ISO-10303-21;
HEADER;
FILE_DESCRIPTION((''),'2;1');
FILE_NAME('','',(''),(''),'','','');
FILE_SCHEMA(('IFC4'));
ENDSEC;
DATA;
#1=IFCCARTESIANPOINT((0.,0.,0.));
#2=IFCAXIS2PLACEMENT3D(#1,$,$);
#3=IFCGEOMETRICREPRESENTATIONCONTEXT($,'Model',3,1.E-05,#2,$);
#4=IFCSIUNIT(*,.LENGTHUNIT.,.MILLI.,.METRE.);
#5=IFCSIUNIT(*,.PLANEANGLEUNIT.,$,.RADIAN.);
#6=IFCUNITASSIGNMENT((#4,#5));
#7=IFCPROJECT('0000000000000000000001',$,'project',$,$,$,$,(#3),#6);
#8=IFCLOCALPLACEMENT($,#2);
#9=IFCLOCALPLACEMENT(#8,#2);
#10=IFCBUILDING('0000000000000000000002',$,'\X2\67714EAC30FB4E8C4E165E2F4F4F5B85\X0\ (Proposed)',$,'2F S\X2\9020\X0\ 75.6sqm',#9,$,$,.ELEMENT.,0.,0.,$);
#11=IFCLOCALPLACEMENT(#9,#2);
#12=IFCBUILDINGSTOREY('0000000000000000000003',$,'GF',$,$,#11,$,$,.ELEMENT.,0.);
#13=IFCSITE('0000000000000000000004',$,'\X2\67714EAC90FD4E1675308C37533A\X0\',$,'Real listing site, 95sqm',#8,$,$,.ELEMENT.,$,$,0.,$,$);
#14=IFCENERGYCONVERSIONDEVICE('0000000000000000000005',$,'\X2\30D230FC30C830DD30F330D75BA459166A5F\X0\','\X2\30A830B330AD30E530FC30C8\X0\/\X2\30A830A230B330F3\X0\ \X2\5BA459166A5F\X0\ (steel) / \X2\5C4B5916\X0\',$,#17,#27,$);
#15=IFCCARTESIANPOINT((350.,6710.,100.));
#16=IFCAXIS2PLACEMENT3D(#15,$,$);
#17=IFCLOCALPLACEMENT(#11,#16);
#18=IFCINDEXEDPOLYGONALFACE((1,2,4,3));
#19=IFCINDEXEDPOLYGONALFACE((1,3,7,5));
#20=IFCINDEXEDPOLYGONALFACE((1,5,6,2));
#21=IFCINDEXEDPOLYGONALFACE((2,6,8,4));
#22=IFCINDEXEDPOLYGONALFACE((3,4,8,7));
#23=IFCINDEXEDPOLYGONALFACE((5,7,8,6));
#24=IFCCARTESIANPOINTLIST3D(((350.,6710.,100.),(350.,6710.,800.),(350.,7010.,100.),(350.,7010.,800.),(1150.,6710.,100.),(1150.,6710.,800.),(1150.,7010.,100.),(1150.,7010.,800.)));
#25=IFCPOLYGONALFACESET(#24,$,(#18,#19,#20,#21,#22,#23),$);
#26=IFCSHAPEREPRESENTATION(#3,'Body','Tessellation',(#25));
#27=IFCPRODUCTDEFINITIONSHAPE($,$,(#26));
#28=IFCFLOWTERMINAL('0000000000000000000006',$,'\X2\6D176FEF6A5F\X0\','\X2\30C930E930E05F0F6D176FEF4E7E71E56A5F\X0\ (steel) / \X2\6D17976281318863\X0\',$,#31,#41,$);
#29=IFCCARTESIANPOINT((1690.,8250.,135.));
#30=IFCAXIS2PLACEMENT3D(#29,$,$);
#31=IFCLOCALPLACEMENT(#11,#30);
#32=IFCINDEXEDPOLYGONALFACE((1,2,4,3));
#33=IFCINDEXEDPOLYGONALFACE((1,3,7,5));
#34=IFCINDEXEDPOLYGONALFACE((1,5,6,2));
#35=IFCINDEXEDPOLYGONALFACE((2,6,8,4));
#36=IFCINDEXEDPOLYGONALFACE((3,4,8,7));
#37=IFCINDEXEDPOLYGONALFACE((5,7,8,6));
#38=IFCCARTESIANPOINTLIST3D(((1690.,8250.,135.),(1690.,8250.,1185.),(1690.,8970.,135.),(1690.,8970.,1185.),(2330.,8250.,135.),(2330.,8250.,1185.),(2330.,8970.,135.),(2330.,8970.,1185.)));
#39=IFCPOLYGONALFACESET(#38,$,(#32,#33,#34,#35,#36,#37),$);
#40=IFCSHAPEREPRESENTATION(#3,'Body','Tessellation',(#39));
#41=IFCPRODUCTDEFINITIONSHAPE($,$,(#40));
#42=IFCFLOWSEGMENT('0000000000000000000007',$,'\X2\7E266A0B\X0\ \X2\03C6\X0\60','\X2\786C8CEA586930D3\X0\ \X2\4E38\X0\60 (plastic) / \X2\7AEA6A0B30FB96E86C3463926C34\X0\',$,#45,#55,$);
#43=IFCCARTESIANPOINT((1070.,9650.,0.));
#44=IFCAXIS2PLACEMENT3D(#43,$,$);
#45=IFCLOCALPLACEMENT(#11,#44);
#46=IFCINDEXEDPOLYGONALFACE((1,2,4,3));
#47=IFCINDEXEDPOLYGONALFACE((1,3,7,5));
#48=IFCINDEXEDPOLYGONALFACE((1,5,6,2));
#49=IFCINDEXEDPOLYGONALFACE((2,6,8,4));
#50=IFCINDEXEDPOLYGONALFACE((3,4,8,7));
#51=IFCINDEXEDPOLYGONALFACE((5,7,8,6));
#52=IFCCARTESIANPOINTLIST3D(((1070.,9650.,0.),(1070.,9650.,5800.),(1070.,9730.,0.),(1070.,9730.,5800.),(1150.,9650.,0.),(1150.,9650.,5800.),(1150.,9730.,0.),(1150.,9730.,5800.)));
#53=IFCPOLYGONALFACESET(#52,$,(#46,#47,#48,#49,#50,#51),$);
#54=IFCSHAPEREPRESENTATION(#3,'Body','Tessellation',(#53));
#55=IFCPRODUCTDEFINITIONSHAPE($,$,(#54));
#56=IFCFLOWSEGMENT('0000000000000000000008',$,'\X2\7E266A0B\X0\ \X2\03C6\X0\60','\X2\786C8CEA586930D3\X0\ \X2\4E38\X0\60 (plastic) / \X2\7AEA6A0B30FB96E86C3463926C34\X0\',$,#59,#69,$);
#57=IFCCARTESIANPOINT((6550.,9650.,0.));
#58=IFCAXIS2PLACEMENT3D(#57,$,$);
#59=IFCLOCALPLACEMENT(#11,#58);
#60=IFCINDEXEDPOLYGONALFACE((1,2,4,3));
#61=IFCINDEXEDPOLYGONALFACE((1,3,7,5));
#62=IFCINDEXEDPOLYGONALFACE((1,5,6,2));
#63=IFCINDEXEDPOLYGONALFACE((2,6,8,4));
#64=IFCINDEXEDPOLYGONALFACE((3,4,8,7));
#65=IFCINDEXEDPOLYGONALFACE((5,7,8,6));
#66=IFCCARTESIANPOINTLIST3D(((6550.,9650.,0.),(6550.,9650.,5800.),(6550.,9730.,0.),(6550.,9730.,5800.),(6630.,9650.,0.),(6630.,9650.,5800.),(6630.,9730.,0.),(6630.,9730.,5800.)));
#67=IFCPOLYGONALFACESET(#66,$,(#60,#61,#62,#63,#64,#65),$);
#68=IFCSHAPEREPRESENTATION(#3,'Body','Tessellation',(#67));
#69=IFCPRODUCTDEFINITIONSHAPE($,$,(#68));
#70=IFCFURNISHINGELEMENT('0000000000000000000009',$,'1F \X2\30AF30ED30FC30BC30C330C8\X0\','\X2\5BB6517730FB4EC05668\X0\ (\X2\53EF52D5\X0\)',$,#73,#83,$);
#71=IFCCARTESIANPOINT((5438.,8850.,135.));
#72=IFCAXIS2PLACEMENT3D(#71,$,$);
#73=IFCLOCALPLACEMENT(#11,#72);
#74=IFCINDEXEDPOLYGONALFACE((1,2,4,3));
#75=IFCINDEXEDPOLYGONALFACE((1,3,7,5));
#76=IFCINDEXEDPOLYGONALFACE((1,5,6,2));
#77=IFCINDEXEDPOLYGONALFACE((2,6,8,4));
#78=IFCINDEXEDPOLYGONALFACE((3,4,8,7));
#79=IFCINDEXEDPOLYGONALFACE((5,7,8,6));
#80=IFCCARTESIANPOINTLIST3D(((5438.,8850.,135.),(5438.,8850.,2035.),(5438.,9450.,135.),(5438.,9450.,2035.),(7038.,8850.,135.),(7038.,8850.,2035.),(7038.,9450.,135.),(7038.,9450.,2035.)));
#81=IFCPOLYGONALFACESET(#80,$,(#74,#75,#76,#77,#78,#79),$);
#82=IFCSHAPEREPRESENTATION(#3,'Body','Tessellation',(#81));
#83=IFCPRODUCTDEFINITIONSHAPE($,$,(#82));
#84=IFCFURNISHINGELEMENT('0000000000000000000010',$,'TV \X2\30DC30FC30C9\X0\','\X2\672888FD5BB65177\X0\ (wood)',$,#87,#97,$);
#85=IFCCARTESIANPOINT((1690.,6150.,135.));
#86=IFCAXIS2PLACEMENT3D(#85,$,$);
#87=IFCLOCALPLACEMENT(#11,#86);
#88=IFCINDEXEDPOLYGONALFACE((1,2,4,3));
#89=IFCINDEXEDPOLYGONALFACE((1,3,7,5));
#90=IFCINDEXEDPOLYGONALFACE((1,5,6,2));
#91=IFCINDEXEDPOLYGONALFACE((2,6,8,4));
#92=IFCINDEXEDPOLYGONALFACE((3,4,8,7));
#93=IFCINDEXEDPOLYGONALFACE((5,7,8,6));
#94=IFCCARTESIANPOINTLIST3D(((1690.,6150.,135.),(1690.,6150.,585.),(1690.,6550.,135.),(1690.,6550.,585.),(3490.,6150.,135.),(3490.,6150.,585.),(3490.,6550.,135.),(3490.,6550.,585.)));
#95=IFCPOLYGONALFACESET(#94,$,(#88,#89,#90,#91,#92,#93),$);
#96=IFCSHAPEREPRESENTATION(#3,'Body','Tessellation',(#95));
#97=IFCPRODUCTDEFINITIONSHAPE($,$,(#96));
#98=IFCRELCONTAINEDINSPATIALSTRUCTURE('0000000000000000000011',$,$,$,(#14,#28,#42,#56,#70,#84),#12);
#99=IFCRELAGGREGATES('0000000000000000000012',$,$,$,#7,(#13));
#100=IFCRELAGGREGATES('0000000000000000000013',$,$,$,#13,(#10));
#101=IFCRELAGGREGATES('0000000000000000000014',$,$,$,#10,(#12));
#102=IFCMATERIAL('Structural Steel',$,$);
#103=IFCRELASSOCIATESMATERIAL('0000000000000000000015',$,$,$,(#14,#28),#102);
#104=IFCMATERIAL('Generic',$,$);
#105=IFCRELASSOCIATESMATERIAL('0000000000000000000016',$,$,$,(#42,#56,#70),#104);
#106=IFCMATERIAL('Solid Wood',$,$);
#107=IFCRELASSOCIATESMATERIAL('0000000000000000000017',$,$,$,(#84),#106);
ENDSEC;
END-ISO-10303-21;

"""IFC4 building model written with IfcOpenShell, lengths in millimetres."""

from ifc_helpers import new_model, si_unit, frame, frame_2d, origin, place, context, project, spatial, rectangle, extrude, material, element, save


model = new_model("IFC4")

# Units and contexts
model_context = context("Model", 3, precision=1e-05, world=origin())
ifc_project = project(units=[si_unit("LENGTHUNIT", "METRE", prefix="MILLI"), si_unit("PLANEANGLEUNIT", "RADIAN")], contexts=[model_context])

# Site, building, storey
site_placement = place(None, origin())
site = spatial("IfcSite", under=ifc_project, at=site_placement, Name="東京都世田谷区", ObjectType="Real listing site, 95sqm", CompositionType="ELEMENT", RefElevation=0.0)
building_placement = place(site_placement, origin())
building = spatial("IfcBuilding", under=site, at=building_placement, Name="東京・二世帯住宅 (Proposed)", ObjectType="2F S造 75.6sqm", CompositionType="ELEMENT", ElevationOfRefHeight=0.0, ElevationOfTerrain=0.0)
storey_placement = place(building_placement, origin())
storey = spatial("IfcBuildingStorey", under=building, at=storey_placement, Name="GF", CompositionType="ELEMENT", Elevation=0.0)

# Shared definitions
ifc_material_1 = material(Name="Solid Wood")

# Shared definitions
ifc_material_2 = material(Name="Generic")

# Shared definitions
ifc_material_3 = material(Name="Structural Steel")

# Energy conversion device
energy_conversion_device_placement = place(storey_placement, frame((350.0, 6710.0, 100.0)))
element("IfcEnergyConversionDevice", 1, at=energy_conversion_device_placement, inside=storey, material=ifc_material_3, Name="ヒートポンプ室外機", Description="エコキュート/エアコン 室外機 (steel) / 屋外", context=model_context, shape_type="SweptSolid", body=[
    extrude(rectangle(XDim=800.0, YDim=300.0, at=frame_2d((400.0, 150.0))), frame((350.0, 6710.0, 100.0)), (0.0, 0.0, 1.0), 700.0),
])

# Flow terminal
flow_terminal_placement = place(storey_placement, frame((1690.0, 8250.0, 135.0)))
element("IfcFlowTerminal", 2, at=flow_terminal_placement, inside=storey, material=ifc_material_3, Name="洗濯機", Description="ドラム式洗濯乾燥機 (steel) / 洗面脱衣", context=model_context, shape_type="SweptSolid", body=[
    extrude(rectangle(XDim=640.0, YDim=720.0, at=frame_2d((320.0, 360.0))), frame((1690.0, 8250.0, 135.0)), (0.0, 0.0, 1.0), 1050.0),
])

# Flow segments
flow_segment_1_placement = place(storey_placement, frame((1070.0, 9650.0, 0.0)))
element("IfcFlowSegment", 3, at=flow_segment_1_placement, inside=storey, material=ifc_material_2, Name="縦樋 φ60", Description="硬質塩ビ 丸60 (plastic) / 竪樋・雨水排水", context=model_context, shape_type="SweptSolid", body=[
    extrude(rectangle(XDim=80.0, YDim=80.0, at=frame_2d((40.0, 40.0))), frame((1070.0, 9650.0, 0.0)), (0.0, 0.0, 1.0), 5800.0),
])
flow_segment_2_placement = place(storey_placement, frame((6550.0, 9650.0, 0.0)))
element("IfcFlowSegment", 4, at=flow_segment_2_placement, inside=storey, material=ifc_material_2, Name="縦樋 φ60", Description="硬質塩ビ 丸60 (plastic) / 竪樋・雨水排水", context=model_context, shape_type="SweptSolid", body=[
    extrude(rectangle(XDim=80.0, YDim=80.0, at=frame_2d((40.0, 40.0))), frame((6550.0, 9650.0, 0.0)), (0.0, 0.0, 1.0), 5800.0),
])

# Furnishing elements
furnishing_1_placement = place(storey_placement, frame((5438.0, 8850.0, 135.0)))
element("IfcFurnishingElement", 5, at=furnishing_1_placement, inside=storey, material=ifc_material_2, Name="1F クローゼット", Description="家具・什器 (可動)", context=model_context, shape_type="SweptSolid", body=[
    extrude(rectangle(XDim=1600.0, YDim=600.0, at=frame_2d((800.0, 300.0))), frame((5438.0, 8850.0, 135.0)), (0.0, 0.0, 1.0), 1900.0),
])
furnishing_2_placement = place(storey_placement, frame((1690.0, 6150.0, 135.0)))
element("IfcFurnishingElement", 6, at=furnishing_2_placement, inside=storey, material=ifc_material_1, Name="TV ボード", Description="木製家具 (wood)", context=model_context, shape_type="SweptSolid", body=[
    extrude(rectangle(XDim=1800.0, YDim=400.0, at=frame_2d((900.0, 200.0))), frame((1690.0, 6150.0, 135.0)), (0.0, 0.0, 1.0), 450.0),
])

save(model, "model.ifc")
